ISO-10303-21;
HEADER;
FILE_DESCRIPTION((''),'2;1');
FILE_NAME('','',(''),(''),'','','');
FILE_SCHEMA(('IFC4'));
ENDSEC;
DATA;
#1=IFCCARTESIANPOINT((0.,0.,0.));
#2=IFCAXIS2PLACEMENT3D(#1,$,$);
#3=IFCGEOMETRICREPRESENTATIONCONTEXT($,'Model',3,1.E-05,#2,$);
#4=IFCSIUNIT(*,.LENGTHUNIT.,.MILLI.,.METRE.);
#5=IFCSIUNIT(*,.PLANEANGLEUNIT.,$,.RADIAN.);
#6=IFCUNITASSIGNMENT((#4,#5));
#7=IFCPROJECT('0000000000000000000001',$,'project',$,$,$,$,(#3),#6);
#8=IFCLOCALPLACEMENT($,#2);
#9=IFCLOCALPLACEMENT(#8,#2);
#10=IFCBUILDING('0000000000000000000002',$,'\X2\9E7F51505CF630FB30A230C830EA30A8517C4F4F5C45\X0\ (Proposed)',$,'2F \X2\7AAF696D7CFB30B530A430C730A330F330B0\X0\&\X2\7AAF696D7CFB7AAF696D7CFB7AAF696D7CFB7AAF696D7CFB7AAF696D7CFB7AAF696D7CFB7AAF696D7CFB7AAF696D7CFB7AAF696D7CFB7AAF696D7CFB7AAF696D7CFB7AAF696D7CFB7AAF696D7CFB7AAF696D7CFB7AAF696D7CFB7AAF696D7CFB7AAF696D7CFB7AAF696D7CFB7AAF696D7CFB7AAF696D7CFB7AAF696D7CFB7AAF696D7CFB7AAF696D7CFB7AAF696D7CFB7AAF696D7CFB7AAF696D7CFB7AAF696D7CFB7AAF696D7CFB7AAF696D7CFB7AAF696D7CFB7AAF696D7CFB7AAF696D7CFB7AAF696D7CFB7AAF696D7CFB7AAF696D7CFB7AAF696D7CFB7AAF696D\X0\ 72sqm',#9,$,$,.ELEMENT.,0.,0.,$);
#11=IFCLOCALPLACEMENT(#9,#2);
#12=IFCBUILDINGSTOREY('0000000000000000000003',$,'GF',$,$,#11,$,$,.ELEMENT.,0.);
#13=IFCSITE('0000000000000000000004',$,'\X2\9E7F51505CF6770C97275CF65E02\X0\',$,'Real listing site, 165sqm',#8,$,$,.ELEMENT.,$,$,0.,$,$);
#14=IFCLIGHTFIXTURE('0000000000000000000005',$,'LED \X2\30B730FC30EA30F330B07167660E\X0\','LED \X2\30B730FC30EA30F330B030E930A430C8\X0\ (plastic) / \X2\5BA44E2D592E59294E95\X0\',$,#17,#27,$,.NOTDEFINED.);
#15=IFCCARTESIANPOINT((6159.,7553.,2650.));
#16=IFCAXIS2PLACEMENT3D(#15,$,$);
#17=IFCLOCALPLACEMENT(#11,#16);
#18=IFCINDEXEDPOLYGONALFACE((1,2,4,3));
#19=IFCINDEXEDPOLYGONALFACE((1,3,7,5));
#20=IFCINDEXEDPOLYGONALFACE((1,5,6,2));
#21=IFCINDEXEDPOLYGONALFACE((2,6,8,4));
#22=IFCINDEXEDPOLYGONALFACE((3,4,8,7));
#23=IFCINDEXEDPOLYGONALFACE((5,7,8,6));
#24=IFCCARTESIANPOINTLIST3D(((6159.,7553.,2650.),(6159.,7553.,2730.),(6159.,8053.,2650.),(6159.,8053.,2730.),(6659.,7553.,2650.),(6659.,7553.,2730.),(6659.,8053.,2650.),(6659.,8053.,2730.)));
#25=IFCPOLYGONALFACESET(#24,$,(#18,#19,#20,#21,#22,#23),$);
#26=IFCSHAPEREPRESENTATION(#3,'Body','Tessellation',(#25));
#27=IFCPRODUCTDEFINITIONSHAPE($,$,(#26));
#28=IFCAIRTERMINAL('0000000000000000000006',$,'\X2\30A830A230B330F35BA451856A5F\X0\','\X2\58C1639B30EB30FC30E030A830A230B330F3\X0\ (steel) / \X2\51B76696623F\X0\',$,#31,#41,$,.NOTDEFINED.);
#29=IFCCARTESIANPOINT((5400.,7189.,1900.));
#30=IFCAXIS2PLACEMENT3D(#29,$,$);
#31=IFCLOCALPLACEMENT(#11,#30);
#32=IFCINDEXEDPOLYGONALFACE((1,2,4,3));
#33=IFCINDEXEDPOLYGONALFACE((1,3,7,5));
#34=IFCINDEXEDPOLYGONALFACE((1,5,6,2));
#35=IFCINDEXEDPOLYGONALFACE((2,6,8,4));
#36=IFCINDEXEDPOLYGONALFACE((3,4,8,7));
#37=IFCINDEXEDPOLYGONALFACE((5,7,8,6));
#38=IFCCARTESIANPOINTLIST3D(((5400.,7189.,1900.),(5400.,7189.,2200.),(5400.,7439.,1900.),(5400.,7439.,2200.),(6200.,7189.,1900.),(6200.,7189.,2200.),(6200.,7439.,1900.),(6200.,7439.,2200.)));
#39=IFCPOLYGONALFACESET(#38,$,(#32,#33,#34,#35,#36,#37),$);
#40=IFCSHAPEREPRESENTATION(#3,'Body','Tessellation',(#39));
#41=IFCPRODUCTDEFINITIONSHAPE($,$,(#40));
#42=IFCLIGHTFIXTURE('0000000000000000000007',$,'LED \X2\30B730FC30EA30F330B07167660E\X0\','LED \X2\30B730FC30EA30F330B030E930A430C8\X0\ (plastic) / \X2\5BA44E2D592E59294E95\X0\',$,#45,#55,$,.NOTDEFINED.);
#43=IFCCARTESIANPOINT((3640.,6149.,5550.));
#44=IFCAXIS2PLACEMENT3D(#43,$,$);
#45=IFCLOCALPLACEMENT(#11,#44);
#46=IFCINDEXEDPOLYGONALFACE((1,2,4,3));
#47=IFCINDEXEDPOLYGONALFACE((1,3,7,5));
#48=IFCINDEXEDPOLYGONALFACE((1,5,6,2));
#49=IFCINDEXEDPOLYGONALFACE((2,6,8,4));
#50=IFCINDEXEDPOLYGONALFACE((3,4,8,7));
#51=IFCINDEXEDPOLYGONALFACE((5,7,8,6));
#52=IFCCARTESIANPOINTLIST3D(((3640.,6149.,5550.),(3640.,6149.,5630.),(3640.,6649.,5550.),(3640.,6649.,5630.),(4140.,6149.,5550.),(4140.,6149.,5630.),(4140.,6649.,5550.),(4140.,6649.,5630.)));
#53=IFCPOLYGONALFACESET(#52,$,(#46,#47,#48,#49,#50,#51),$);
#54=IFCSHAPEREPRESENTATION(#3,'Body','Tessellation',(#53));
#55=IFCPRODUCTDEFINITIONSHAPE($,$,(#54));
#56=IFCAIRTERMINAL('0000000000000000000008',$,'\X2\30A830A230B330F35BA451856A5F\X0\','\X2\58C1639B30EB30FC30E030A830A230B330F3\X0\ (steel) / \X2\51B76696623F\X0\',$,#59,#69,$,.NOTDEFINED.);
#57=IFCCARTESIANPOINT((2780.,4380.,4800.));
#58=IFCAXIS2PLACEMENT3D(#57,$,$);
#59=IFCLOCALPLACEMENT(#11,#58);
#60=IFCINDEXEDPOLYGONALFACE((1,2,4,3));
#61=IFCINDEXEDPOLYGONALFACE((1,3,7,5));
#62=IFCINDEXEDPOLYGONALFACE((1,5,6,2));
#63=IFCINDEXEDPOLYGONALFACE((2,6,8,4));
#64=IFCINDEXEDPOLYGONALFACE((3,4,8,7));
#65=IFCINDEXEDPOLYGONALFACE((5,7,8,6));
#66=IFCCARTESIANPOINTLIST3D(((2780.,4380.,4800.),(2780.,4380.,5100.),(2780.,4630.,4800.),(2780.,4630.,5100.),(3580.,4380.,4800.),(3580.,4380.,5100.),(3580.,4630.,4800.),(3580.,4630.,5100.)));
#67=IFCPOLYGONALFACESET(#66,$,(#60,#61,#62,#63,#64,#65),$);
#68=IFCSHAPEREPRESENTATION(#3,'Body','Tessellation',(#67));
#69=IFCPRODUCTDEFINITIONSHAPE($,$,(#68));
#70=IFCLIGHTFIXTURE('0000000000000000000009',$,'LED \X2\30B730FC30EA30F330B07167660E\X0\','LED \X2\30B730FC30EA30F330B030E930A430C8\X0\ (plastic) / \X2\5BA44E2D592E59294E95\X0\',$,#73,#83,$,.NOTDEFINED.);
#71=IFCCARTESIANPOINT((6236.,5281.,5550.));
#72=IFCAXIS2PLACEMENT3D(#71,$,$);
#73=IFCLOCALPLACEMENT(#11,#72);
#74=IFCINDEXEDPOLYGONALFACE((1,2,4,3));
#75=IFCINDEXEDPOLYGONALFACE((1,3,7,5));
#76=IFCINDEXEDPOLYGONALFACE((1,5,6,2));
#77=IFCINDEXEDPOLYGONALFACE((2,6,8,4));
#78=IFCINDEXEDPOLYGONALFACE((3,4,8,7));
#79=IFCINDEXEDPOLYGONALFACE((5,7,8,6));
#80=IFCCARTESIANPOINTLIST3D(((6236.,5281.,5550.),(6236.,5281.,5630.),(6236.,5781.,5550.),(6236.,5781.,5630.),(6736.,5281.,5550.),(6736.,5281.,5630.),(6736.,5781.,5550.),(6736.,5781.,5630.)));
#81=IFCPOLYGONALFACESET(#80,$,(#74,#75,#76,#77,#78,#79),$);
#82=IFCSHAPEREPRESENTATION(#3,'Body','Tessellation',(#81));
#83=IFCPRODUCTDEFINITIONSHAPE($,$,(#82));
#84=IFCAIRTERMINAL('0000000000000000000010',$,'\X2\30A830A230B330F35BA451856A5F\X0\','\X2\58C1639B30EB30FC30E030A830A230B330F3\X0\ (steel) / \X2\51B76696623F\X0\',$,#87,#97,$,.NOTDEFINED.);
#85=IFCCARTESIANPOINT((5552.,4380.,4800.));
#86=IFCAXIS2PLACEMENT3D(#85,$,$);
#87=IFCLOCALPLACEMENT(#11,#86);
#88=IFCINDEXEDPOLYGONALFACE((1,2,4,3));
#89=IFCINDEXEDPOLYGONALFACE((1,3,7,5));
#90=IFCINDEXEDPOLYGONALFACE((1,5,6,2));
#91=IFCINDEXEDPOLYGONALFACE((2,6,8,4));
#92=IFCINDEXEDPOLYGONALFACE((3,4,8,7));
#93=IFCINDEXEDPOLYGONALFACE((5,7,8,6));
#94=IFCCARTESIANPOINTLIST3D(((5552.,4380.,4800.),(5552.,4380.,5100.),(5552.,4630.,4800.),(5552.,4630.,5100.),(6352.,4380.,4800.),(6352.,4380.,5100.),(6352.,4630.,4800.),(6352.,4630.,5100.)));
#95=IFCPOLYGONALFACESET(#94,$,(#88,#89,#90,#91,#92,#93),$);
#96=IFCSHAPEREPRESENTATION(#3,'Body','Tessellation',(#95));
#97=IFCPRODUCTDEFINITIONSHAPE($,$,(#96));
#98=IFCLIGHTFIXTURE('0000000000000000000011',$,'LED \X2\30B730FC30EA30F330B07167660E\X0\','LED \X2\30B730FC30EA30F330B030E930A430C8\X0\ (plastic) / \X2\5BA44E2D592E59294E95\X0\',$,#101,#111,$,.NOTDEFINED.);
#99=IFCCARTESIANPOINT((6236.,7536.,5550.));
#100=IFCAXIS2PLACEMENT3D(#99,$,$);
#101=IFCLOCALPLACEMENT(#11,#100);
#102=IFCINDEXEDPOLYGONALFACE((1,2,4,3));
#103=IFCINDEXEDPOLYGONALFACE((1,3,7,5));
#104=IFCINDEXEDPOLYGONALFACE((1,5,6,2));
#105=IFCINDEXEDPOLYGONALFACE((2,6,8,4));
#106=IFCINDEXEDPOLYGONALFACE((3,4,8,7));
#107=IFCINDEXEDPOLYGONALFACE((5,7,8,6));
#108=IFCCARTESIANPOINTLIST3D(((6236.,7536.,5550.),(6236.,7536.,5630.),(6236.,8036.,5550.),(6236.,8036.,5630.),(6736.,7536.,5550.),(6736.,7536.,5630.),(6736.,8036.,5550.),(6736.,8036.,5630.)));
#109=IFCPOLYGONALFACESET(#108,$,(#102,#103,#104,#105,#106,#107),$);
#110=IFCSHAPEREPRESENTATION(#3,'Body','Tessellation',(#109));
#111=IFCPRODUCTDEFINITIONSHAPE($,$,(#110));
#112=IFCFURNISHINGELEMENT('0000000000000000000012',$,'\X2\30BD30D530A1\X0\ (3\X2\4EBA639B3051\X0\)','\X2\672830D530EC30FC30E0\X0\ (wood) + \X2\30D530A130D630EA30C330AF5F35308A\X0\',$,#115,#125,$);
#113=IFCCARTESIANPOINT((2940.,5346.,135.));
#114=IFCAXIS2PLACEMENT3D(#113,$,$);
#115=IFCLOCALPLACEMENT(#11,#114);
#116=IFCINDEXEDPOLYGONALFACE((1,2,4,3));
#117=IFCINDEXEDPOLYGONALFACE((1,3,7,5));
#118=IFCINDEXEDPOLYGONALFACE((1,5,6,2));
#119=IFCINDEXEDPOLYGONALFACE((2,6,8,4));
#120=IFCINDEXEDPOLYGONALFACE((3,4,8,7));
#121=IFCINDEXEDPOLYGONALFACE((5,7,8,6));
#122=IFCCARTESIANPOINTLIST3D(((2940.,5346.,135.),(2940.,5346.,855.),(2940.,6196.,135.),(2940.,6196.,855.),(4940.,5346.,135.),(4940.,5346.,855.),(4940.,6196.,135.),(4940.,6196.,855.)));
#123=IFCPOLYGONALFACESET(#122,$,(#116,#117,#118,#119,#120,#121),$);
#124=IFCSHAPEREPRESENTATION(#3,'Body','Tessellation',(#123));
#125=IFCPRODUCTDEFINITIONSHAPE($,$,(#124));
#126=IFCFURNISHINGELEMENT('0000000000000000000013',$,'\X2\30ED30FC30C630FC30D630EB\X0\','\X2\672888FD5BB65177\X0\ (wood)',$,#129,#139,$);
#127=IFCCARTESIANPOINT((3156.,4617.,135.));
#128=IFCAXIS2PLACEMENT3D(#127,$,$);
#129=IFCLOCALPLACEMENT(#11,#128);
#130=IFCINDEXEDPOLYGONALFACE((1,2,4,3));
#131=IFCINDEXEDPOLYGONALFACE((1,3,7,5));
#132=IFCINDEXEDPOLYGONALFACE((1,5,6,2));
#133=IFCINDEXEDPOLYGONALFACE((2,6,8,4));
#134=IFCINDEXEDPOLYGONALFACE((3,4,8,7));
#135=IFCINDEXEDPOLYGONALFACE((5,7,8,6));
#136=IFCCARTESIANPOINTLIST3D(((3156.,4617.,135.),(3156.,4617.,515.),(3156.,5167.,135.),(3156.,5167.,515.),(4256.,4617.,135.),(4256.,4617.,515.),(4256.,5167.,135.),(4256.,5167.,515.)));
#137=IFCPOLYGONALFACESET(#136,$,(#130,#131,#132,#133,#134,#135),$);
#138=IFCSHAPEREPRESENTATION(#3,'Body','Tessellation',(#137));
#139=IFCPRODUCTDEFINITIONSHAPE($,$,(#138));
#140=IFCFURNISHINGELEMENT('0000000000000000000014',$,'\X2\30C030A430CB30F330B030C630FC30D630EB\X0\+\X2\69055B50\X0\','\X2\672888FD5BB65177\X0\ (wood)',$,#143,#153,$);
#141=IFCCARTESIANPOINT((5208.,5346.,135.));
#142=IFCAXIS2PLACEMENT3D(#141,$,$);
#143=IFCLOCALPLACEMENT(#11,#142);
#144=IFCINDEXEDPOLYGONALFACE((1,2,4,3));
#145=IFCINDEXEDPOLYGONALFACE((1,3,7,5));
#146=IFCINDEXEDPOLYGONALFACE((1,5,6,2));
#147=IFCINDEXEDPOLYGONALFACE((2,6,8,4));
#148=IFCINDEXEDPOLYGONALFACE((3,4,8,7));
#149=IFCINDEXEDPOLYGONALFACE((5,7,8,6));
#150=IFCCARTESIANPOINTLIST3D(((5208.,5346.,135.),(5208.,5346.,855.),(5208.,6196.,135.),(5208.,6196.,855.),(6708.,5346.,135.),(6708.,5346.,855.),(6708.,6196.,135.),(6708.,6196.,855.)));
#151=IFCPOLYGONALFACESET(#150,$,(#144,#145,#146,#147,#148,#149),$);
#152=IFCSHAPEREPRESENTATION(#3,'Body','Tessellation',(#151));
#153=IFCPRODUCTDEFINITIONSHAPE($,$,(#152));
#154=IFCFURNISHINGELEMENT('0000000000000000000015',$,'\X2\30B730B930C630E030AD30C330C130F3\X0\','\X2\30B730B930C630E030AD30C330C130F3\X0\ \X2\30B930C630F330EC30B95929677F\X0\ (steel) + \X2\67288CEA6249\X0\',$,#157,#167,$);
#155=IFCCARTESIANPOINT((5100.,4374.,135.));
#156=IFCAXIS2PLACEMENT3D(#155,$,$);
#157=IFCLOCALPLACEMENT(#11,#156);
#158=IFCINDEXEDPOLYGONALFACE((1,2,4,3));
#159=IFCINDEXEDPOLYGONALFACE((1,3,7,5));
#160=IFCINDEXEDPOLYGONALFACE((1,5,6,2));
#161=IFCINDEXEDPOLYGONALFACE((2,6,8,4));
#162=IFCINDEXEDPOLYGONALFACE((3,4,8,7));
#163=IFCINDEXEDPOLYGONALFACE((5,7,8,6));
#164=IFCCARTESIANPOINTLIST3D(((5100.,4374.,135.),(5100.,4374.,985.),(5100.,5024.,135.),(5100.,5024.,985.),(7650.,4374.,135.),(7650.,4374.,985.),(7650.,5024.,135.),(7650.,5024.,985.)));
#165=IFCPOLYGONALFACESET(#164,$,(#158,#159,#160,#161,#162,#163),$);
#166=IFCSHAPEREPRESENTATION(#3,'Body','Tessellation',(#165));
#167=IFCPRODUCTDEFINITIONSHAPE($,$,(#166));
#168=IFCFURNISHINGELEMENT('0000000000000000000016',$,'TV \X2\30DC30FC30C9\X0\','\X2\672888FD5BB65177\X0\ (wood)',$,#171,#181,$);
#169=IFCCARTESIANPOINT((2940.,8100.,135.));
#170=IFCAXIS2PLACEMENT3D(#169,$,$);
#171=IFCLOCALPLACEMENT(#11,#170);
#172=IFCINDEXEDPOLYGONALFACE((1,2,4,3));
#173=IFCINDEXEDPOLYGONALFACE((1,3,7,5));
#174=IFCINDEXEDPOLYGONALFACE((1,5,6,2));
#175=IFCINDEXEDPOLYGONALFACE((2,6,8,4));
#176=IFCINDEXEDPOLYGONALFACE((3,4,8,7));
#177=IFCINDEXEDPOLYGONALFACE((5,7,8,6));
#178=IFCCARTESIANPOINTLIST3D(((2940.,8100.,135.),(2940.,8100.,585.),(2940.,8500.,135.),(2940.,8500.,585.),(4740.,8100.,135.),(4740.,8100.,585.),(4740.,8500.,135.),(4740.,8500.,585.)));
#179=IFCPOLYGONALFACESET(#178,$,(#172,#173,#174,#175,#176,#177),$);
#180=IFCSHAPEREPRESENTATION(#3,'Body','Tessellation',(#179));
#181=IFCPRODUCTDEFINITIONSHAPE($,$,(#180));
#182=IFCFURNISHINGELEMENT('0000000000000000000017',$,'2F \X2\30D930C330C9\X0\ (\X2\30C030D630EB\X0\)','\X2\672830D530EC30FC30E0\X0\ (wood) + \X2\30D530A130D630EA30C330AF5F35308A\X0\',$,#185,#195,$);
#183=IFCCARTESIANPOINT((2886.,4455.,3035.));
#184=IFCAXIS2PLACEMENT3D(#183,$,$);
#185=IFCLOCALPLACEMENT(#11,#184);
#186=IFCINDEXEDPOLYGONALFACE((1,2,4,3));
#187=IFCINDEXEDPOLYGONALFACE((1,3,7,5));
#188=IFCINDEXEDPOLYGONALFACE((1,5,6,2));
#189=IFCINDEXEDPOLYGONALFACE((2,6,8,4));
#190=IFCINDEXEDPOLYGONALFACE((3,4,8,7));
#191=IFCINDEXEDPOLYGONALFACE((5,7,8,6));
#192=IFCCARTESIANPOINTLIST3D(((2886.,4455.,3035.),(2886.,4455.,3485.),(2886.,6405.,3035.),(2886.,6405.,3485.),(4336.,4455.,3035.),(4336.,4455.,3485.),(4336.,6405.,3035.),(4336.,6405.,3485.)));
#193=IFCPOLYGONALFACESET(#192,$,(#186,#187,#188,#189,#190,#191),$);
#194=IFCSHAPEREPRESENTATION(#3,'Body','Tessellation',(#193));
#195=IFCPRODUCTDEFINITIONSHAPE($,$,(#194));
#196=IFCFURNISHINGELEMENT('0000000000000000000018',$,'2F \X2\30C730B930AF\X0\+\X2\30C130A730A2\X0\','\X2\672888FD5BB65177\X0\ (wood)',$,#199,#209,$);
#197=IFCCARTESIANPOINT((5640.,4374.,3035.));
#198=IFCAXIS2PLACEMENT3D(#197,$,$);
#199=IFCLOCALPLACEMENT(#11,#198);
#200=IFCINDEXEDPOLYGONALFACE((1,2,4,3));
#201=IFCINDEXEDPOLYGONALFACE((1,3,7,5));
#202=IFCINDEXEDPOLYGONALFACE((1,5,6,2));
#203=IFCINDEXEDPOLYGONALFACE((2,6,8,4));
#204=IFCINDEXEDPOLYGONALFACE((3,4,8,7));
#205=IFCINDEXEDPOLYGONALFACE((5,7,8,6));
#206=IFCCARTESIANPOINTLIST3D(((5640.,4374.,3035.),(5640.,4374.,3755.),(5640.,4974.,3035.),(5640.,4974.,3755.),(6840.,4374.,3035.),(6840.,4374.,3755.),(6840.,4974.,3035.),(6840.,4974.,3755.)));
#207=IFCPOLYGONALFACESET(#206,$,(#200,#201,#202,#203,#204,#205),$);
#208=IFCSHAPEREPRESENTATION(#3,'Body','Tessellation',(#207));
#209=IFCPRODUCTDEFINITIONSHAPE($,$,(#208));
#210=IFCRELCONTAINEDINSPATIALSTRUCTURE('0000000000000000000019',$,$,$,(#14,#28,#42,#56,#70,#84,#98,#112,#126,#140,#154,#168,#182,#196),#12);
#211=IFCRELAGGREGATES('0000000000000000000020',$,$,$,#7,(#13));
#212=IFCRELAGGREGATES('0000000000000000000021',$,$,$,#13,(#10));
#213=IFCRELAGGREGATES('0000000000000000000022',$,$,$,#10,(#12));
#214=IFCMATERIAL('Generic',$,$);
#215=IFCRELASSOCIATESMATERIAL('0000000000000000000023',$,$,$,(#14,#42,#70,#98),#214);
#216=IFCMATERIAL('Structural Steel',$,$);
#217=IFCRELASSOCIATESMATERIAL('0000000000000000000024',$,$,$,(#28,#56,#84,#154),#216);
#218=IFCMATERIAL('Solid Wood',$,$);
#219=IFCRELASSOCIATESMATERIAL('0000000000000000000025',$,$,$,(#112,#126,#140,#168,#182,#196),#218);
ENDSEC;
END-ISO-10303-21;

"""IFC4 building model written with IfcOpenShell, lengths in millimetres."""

from ifc_helpers import new_model, si_unit, frame, frame_2d, origin, place, context, project, spatial, rectangle, extrude, material, element, save


model = new_model("IFC4")

# Units and contexts
model_context = context("Model", 3, precision=1e-05, world=origin())
ifc_project = project(units=[si_unit("LENGTHUNIT", "METRE", prefix="MILLI"), si_unit("PLANEANGLEUNIT", "RADIAN")], contexts=[model_context])

# Site, building, storey
site_placement = place(None, origin())
site = spatial("IfcSite", under=ifc_project, at=site_placement, Name="鹿児島県霧島市", ObjectType="Real listing site, 165sqm", CompositionType="ELEMENT", RefElevation=0.0)
building_placement = place(site_placement, origin())
building = spatial("IfcBuilding", under=site, at=building_placement, Name="鹿児島・アトリエ兼住居 (Proposed)", ObjectType="2F 窯業系サイディング&窯業系窯業系窯業系窯業系窯業系窯業系窯業系窯業系窯業系窯業系窯業系窯業系窯業系窯業系窯業系窯業系窯業系窯業系窯業系窯業系窯業系窯業系窯業系窯業系窯業系窯業系窯業系窯業系窯業系窯業系窯業系窯業系窯業系窯業系窯業系窯業系窯業 72sqm", CompositionType="ELEMENT", ElevationOfRefHeight=0.0, ElevationOfTerrain=0.0)
storey_placement = place(building_placement, origin())
storey = spatial("IfcBuildingStorey", under=building, at=storey_placement, Name="GF", CompositionType="ELEMENT", Elevation=0.0)

# Shared definitions
ifc_material_1 = material(Name="Solid Wood")

# Shared definitions
ifc_material_2 = material(Name="Structural Steel")

# Shared definitions
ifc_material_3 = material(Name="Generic")

# Light fixture
light_fixture_1_placement = place(storey_placement, frame((6159.0, 7553.0, 2650.0)))
element("IfcLightFixture", 1, at=light_fixture_1_placement, inside=storey, material=ifc_material_3, Name="LED シーリング照明", Description="LED シーリングライト (plastic) / 室中央天井", PredefinedType="NOTDEFINED", context=model_context, shape_type="SweptSolid", body=[
    extrude(rectangle(XDim=500.0, YDim=500.0, at=frame_2d((250.0, 250.0))), frame((6159.0, 7553.0, 2650.0)), (0.0, 0.0, 1.0), 80.0),
])

# Air terminal
air_terminal_1_placement = place(storey_placement, frame((5400.0, 7189.0, 1900.0)))
element("IfcAirTerminal", 2, at=air_terminal_1_placement, inside=storey, material=ifc_material_2, Name="エアコン室内機", Description="壁掛ルームエアコン (steel) / 冷暖房", PredefinedType="NOTDEFINED", context=model_context, shape_type="SweptSolid", body=[
    extrude(rectangle(XDim=800.0, YDim=250.0, at=frame_2d((400.0, 125.0))), frame((5400.0, 7189.0, 1900.0)), (0.0, 0.0, 1.0), 300.0),
])

# Light fixture
light_fixture_2_placement = place(storey_placement, frame((3640.0, 6149.0, 5550.0)))
element("IfcLightFixture", 3, at=light_fixture_2_placement, inside=storey, material=ifc_material_3, Name="LED シーリング照明", Description="LED シーリングライト (plastic) / 室中央天井", PredefinedType="NOTDEFINED", context=model_context, shape_type="SweptSolid", body=[
    extrude(rectangle(XDim=500.0, YDim=500.0, at=frame_2d((250.0, 250.0))), frame((3640.0, 6149.0, 5550.0)), (0.0, 0.0, 1.0), 80.0),
])

# Air terminal
air_terminal_2_placement = place(storey_placement, frame((2780.0, 4380.0, 4800.0)))
element("IfcAirTerminal", 4, at=air_terminal_2_placement, inside=storey, material=ifc_material_2, Name="エアコン室内機", Description="壁掛ルームエアコン (steel) / 冷暖房", PredefinedType="NOTDEFINED", context=model_context, shape_type="SweptSolid", body=[
    extrude(rectangle(XDim=800.0, YDim=250.0, at=frame_2d((400.0, 125.0))), frame((2780.0, 4380.0, 4800.0)), (0.0, 0.0, 1.0), 300.0),
])

# Light fixture
light_fixture_3_placement = place(storey_placement, frame((6236.0, 5281.0, 5550.0)))
element("IfcLightFixture", 5, at=light_fixture_3_placement, inside=storey, material=ifc_material_3, Name="LED シーリング照明", Description="LED シーリングライト (plastic) / 室中央天井", PredefinedType="NOTDEFINED", context=model_context, shape_type="SweptSolid", body=[
    extrude(rectangle(XDim=500.0, YDim=500.0, at=frame_2d((250.0, 250.0))), frame((6236.0, 5281.0, 5550.0)), (0.0, 0.0, 1.0), 80.0),
])

# Air terminal
air_terminal_3_placement = place(storey_placement, frame((5552.0, 4380.0, 4800.0)))
element("IfcAirTerminal", 6, at=air_terminal_3_placement, inside=storey, material=ifc_material_2, Name="エアコン室内機", Description="壁掛ルームエアコン (steel) / 冷暖房", PredefinedType="NOTDEFINED", context=model_context, shape_type="SweptSolid", body=[
    extrude(rectangle(XDim=800.0, YDim=250.0, at=frame_2d((400.0, 125.0))), frame((5552.0, 4380.0, 4800.0)), (0.0, 0.0, 1.0), 300.0),
])

# Light fixture
light_fixture_4_placement = place(storey_placement, frame((6236.0, 7536.0, 5550.0)))
element("IfcLightFixture", 7, at=light_fixture_4_placement, inside=storey, material=ifc_material_3, Name="LED シーリング照明", Description="LED シーリングライト (plastic) / 室中央天井", PredefinedType="NOTDEFINED", context=model_context, shape_type="SweptSolid", body=[
    extrude(rectangle(XDim=500.0, YDim=500.0, at=frame_2d((250.0, 250.0))), frame((6236.0, 7536.0, 5550.0)), (0.0, 0.0, 1.0), 80.0),
])

# Furnishing elements
furnishing_1_placement = place(storey_placement, frame((2940.0, 5346.0, 135.0)))
element("IfcFurnishingElement", 8, at=furnishing_1_placement, inside=storey, material=ifc_material_1, Name="ソファ (3人掛け)", Description="木フレーム (wood) + ファブリック張り", context=model_context, shape_type="SweptSolid", body=[
    extrude(rectangle(XDim=2000.0, YDim=850.0, at=frame_2d((1000.0, 425.0))), frame((2940.0, 5346.0, 135.0)), (0.0, 0.0, 1.0), 720.0),
])
furnishing_2_placement = place(storey_placement, frame((3156.0, 4617.0, 135.0)))
element("IfcFurnishingElement", 9, at=furnishing_2_placement, inside=storey, material=ifc_material_1, Name="ローテーブル", Description="木製家具 (wood)", context=model_context, shape_type="SweptSolid", body=[
    extrude(rectangle(XDim=1100.0, YDim=550.0, at=frame_2d((550.0, 275.0))), frame((3156.0, 4617.0, 135.0)), (0.0, 0.0, 1.0), 380.0),
])
furnishing_3_placement = place(storey_placement, frame((5208.0, 5346.0, 135.0)))
element("IfcFurnishingElement", 10, at=furnishing_3_placement, inside=storey, material=ifc_material_1, Name="ダイニングテーブル+椅子", Description="木製家具 (wood)", context=model_context, shape_type="SweptSolid", body=[
    extrude(rectangle(XDim=1500.0, YDim=850.0, at=frame_2d((750.0, 425.0))), frame((5208.0, 5346.0, 135.0)), (0.0, 0.0, 1.0), 720.0),
])
furnishing_4_placement = place(storey_placement, frame((5100.0, 4374.0, 135.0)))
element("IfcFurnishingElement", 11, at=furnishing_4_placement, inside=storey, material=ifc_material_2, Name="システムキッチン", Description="システムキッチン ステンレス天板 (steel) + 木質扉", context=model_context, shape_type="SweptSolid", body=[
    extrude(rectangle(XDim=2550.0, YDim=650.0, at=frame_2d((1275.0, 325.0))), frame((5100.0, 4374.0, 135.0)), (0.0, 0.0, 1.0), 850.0),
])
furnishing_5_placement = place(storey_placement, frame((2940.0, 8100.0, 135.0)))
element("IfcFurnishingElement", 12, at=furnishing_5_placement, inside=storey, material=ifc_material_1, Name="TV ボード", Description="木製家具 (wood)", context=model_context, shape_type="SweptSolid", body=[
    extrude(rectangle(XDim=1800.0, YDim=400.0, at=frame_2d((900.0, 200.0))), frame((2940.0, 8100.0, 135.0)), (0.0, 0.0, 1.0), 450.0),
])
furnishing_6_placement = place(storey_placement, frame((2886.0, 4455.0, 3035.0)))
element("IfcFurnishingElement", 13, at=furnishing_6_placement, inside=storey, material=ifc_material_1, Name="2F ベッド (ダブル)", Description="木フレーム (wood) + ファブリック張り", context=model_context, shape_type="SweptSolid", body=[
    extrude(rectangle(XDim=1450.0, YDim=1950.0, at=frame_2d((725.0, 975.0))), frame((2886.0, 4455.0, 3035.0)), (0.0, 0.0, 1.0), 450.0),
])
furnishing_7_placement = place(storey_placement, frame((5640.0, 4374.0, 3035.0)))
element("IfcFurnishingElement", 14, at=furnishing_7_placement, inside=storey, material=ifc_material_1, Name="2F デスク+チェア", Description="木製家具 (wood)", context=model_context, shape_type="SweptSolid", body=[
    extrude(rectangle(XDim=1200.0, YDim=600.0, at=frame_2d((600.0, 300.0))), frame((5640.0, 4374.0, 3035.0)), (0.0, 0.0, 1.0), 720.0),
])

save(model, "model.ifc")
